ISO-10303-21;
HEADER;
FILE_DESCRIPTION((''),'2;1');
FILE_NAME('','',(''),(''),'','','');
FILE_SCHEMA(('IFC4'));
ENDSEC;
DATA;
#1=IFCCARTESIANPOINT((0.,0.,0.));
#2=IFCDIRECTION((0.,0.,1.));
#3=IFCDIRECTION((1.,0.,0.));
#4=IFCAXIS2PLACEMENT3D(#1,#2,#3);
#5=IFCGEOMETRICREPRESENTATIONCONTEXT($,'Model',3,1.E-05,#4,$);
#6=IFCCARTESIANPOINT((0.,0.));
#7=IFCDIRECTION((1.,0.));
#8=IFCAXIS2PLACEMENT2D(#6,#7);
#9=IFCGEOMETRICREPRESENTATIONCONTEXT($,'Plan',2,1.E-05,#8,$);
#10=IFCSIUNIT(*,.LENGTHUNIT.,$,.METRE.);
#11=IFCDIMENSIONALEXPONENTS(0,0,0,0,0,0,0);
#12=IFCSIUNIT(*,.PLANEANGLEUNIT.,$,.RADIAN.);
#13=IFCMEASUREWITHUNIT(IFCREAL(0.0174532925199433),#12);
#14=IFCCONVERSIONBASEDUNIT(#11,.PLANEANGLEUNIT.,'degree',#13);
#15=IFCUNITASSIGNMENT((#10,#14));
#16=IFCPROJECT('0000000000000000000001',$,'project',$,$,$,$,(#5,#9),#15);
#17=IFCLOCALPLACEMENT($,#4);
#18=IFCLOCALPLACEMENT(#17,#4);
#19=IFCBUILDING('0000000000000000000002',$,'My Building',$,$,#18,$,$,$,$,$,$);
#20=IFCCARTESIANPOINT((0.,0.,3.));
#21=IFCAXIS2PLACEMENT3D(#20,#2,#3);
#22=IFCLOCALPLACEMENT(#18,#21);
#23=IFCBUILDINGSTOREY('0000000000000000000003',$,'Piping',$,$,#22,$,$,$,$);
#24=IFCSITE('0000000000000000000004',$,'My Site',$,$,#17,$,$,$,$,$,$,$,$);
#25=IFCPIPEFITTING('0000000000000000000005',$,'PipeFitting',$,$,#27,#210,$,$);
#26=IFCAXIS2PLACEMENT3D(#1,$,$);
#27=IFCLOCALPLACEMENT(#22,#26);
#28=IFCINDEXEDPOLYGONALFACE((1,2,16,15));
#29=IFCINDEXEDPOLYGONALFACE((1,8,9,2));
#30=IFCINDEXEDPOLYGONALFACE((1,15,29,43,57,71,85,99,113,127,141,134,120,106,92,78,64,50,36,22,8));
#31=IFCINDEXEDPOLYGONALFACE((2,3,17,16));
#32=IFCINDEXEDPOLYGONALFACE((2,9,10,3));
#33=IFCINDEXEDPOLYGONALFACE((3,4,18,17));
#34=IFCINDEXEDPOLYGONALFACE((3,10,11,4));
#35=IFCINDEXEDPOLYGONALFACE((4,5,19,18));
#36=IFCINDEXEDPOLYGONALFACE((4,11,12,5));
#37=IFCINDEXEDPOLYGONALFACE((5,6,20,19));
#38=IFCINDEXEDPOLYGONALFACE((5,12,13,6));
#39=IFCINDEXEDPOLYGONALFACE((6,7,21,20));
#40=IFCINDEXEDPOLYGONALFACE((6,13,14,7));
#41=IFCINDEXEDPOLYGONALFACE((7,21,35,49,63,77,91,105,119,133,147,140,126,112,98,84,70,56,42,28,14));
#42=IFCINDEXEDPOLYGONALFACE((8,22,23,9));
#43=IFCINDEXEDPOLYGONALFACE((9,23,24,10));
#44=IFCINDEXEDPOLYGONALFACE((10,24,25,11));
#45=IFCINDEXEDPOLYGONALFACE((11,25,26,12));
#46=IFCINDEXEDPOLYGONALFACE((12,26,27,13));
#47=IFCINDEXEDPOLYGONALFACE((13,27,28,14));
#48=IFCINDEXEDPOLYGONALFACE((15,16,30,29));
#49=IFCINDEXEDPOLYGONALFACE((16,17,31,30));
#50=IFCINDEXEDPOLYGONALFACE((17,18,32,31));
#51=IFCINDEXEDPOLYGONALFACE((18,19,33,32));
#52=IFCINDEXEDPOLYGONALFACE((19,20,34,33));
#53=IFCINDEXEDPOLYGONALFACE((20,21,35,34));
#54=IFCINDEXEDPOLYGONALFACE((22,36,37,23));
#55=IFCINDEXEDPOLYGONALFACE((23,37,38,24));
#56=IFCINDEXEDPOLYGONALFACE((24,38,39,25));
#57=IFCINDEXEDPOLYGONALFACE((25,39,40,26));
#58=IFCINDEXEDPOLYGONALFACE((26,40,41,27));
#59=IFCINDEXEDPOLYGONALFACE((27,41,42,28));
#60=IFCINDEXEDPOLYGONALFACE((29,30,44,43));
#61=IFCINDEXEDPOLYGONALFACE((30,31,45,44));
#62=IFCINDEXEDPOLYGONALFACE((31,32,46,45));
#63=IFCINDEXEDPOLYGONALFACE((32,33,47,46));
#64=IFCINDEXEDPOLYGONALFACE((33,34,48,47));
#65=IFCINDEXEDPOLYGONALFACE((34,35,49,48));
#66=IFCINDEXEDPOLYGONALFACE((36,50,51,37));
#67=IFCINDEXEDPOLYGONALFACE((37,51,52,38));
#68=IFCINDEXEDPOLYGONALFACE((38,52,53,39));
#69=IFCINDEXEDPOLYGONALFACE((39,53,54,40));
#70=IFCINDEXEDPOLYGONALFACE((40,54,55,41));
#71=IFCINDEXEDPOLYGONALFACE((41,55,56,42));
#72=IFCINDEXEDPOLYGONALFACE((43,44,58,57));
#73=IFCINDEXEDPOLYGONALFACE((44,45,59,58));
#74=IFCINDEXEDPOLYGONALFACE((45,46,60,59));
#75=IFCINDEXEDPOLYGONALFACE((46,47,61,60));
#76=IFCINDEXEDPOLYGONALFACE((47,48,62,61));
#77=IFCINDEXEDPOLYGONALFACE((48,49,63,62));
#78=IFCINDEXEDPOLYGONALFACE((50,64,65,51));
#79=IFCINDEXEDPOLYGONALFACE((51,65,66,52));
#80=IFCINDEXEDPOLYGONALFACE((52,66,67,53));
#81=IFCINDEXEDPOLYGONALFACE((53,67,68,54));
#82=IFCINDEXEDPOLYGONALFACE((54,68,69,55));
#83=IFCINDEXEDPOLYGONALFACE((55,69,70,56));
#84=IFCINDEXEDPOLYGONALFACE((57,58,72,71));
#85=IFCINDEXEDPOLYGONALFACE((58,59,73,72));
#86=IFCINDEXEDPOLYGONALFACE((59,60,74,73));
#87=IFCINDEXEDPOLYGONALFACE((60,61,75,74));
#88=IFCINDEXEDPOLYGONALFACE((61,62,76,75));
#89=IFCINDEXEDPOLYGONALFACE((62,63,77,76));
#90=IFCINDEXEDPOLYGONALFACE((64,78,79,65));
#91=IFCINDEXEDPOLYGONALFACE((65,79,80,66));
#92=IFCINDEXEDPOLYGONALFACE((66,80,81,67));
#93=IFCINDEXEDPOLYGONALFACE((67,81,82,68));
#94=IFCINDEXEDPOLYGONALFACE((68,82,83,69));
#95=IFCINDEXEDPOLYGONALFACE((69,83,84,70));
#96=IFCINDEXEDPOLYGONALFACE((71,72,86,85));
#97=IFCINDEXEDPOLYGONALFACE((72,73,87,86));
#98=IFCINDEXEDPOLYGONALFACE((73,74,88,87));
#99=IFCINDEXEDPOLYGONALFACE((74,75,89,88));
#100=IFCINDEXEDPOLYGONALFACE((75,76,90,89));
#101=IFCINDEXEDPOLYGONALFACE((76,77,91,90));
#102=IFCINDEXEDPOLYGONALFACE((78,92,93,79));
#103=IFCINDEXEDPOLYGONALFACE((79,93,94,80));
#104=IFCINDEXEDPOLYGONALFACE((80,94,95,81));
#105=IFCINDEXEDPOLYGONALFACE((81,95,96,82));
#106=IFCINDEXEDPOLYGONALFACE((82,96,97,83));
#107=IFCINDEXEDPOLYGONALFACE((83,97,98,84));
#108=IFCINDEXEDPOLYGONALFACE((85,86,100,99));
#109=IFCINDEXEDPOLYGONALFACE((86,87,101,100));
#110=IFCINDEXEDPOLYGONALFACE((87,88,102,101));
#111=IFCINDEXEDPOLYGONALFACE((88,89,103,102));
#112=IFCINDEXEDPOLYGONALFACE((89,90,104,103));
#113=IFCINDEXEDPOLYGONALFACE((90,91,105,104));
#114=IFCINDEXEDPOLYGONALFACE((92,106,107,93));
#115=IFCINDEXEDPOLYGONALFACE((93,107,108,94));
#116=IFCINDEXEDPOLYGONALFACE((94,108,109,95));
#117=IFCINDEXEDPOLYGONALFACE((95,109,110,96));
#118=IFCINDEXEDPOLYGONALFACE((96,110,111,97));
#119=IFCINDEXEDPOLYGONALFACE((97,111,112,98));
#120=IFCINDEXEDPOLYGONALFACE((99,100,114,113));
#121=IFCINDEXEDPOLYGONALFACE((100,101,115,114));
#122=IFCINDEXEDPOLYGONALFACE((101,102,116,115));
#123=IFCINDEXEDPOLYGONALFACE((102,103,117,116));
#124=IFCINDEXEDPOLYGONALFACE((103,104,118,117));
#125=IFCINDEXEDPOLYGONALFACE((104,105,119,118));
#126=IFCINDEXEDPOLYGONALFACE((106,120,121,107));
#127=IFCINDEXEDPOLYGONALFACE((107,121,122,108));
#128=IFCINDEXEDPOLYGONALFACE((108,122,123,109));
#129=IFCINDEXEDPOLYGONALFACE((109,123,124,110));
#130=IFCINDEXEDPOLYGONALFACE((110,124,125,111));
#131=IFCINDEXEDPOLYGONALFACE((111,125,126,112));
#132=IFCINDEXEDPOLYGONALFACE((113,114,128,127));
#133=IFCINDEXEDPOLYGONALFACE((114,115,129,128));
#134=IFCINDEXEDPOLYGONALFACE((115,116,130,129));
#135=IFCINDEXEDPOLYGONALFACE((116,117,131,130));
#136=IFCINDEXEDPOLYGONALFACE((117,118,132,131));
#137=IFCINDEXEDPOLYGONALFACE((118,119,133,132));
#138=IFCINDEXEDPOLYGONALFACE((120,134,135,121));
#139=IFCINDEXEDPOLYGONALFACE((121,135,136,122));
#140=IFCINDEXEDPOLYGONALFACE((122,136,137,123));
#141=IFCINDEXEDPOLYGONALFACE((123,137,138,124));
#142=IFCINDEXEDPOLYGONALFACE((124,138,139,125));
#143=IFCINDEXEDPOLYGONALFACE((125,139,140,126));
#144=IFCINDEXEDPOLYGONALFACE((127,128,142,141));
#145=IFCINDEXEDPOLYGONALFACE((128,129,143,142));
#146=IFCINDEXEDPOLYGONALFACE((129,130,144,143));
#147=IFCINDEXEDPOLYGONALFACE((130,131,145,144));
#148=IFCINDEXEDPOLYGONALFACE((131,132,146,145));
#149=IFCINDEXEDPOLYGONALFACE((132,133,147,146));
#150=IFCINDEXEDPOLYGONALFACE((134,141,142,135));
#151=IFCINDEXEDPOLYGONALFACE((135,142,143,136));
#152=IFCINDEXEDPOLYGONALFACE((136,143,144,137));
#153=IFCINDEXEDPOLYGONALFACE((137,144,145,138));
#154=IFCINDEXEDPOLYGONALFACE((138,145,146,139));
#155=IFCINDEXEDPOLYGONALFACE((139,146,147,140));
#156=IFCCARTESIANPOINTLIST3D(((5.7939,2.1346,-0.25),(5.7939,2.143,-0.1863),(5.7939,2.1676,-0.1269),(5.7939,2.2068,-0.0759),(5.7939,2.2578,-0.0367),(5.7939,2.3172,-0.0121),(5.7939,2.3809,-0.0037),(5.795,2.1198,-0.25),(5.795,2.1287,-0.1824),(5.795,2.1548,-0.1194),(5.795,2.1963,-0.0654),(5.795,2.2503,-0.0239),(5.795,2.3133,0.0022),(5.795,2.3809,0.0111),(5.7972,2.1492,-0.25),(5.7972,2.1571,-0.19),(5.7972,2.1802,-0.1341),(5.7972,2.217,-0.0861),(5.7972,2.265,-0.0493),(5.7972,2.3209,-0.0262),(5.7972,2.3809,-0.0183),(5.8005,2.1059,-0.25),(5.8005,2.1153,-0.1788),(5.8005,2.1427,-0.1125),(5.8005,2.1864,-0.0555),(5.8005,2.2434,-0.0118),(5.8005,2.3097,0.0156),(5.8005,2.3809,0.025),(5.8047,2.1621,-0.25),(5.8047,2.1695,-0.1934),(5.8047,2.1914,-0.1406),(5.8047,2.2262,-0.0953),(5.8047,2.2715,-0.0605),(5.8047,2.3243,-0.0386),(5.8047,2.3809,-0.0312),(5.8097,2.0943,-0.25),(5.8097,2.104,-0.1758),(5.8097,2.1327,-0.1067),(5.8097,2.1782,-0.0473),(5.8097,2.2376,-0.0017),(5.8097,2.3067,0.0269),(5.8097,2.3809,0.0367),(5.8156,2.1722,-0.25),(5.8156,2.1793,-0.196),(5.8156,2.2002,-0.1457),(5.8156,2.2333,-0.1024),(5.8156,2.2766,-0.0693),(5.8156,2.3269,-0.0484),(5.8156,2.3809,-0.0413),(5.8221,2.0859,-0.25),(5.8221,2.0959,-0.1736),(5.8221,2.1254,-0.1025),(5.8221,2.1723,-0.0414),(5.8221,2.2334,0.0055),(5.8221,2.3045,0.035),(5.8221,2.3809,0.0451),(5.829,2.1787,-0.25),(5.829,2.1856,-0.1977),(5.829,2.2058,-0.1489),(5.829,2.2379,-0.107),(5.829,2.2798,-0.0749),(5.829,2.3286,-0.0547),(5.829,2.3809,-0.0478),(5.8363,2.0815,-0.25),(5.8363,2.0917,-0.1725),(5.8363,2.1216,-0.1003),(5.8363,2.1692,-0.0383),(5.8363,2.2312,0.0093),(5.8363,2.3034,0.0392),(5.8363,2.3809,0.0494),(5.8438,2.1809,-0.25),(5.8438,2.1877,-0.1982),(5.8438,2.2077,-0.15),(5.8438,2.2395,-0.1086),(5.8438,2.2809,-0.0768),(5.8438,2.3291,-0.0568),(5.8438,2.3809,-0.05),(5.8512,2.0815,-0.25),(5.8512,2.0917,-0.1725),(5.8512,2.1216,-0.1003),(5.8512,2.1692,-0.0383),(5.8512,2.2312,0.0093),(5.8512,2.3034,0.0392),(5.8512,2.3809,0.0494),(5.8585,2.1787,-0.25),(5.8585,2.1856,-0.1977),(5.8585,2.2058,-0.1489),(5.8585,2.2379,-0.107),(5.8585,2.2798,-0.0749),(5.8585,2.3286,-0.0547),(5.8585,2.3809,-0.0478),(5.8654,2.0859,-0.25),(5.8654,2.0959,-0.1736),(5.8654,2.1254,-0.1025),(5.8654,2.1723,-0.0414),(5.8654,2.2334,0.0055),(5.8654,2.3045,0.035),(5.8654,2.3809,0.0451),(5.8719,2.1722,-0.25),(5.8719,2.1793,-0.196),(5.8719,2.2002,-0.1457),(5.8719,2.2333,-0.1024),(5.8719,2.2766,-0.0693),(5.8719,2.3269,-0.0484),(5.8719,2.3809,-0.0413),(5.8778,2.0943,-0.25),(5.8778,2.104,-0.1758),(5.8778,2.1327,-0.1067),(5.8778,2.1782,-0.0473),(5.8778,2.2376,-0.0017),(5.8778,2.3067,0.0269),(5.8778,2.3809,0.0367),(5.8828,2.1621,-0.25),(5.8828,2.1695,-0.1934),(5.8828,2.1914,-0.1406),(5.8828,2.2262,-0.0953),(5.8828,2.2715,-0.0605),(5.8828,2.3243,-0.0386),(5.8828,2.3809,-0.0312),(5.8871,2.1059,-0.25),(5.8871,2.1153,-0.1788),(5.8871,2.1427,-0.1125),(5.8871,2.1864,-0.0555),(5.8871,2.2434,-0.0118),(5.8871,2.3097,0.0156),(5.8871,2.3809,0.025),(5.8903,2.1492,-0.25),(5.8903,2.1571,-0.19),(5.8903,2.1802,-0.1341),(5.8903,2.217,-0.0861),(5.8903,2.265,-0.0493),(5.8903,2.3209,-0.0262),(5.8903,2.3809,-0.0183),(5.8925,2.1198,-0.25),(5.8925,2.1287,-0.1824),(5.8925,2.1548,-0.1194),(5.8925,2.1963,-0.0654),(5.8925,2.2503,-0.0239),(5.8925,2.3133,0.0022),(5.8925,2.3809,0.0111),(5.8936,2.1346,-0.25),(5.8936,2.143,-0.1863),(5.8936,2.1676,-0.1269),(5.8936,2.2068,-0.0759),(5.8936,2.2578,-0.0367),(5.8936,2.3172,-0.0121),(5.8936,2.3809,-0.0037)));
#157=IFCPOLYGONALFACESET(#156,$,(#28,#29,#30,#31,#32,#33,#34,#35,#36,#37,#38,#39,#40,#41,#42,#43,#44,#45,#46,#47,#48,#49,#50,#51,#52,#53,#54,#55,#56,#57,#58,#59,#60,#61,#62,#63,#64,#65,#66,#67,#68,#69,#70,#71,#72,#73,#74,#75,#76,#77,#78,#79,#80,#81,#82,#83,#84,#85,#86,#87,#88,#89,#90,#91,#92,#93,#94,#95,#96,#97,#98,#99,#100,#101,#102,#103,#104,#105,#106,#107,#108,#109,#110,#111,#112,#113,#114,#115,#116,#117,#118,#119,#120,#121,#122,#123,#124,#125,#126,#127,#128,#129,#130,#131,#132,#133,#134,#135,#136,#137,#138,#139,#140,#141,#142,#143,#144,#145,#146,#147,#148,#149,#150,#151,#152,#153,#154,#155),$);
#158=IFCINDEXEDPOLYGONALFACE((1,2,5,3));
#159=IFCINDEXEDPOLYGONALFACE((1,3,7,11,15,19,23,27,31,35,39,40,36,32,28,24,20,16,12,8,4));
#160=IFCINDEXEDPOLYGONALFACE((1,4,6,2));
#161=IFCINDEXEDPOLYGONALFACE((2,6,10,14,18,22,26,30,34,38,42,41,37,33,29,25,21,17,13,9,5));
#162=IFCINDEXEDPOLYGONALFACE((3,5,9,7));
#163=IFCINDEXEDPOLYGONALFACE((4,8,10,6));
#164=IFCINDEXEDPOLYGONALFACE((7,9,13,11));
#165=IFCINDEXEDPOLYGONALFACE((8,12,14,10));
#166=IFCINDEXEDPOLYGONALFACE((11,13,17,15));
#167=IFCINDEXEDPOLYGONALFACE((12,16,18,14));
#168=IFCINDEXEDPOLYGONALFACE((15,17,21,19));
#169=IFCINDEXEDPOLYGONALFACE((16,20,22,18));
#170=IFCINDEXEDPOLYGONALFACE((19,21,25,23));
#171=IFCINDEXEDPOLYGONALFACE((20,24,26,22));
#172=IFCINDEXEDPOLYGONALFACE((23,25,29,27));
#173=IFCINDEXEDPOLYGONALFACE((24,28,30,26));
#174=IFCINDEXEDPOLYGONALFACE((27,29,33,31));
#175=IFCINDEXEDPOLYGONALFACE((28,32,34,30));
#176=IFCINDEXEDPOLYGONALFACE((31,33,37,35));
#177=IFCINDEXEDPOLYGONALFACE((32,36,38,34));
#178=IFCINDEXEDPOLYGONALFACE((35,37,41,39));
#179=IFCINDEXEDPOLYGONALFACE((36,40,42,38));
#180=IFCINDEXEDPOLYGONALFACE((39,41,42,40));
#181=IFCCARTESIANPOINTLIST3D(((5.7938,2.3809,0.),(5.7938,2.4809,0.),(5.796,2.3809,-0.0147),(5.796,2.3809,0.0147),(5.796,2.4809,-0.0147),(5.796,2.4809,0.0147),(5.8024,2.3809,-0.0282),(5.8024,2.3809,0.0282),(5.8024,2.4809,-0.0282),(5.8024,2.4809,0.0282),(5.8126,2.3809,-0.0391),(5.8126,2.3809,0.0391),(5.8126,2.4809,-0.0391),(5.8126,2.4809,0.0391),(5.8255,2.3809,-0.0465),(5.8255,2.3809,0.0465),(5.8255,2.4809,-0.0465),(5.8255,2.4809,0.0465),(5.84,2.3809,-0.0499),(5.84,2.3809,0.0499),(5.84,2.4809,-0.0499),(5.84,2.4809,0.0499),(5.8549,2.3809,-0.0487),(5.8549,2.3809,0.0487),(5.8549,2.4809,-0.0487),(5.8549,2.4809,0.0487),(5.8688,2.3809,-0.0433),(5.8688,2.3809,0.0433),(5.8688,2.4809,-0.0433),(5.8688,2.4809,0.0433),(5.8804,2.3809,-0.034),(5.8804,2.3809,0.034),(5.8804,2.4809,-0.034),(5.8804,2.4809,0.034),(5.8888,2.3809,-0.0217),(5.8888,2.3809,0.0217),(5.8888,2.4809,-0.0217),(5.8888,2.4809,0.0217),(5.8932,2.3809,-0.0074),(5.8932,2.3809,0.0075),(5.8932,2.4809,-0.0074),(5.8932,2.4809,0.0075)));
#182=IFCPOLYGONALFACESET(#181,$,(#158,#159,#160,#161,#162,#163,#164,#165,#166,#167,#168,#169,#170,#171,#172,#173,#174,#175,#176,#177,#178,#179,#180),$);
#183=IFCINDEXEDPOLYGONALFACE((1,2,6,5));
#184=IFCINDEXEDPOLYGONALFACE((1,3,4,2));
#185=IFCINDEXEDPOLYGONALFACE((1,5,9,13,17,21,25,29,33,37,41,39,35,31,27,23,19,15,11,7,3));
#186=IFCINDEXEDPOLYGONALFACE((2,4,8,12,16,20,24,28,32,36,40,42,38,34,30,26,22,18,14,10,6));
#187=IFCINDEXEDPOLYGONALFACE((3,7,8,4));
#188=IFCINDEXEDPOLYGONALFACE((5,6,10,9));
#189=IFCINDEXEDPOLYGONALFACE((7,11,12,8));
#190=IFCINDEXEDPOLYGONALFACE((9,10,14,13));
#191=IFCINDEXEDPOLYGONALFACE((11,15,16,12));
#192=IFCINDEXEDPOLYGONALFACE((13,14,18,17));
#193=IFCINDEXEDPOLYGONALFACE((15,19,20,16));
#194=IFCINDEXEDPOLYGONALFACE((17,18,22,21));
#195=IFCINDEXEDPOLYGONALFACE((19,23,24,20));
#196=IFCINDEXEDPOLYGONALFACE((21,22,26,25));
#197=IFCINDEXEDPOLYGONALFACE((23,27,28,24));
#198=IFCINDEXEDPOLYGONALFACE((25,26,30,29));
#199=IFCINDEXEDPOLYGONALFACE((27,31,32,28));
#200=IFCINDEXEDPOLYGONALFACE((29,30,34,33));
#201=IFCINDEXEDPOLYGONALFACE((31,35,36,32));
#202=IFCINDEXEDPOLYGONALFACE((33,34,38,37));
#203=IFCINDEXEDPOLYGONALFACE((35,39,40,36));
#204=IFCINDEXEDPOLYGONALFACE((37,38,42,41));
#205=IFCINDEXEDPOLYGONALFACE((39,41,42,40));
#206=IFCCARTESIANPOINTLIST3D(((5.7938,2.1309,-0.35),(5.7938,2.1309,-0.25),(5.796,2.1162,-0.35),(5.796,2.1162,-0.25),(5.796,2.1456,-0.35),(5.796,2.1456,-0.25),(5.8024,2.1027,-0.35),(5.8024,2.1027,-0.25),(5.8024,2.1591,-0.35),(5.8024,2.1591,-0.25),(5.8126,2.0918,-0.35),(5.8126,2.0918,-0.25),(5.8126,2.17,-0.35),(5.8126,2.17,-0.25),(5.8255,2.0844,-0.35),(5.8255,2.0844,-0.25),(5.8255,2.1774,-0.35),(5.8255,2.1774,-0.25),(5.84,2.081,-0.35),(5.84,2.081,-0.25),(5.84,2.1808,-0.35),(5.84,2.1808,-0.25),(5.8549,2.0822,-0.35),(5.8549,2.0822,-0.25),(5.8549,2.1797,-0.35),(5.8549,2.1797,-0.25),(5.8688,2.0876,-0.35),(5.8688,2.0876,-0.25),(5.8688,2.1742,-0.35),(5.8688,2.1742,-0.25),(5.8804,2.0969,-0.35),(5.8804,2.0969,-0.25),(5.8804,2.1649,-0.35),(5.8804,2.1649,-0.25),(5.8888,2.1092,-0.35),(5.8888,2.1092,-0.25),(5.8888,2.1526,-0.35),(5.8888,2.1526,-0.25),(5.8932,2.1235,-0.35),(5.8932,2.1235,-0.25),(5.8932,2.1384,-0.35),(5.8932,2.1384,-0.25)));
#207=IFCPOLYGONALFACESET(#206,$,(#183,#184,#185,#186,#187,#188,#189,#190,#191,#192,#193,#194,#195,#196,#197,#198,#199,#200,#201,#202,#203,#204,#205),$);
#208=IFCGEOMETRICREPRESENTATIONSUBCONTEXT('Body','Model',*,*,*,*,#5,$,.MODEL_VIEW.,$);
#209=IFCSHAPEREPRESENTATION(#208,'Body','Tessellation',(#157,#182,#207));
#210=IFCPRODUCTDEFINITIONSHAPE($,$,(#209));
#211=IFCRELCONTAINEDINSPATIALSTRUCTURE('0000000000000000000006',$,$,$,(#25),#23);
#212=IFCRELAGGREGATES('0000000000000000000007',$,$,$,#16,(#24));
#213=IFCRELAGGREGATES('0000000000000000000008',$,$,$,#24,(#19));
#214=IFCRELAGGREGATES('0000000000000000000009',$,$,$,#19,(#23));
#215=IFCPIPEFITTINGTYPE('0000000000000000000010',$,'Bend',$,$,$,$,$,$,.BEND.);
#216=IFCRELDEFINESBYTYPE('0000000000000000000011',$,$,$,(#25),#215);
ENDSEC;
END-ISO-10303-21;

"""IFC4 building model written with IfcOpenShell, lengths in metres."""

from ifc_helpers import new_model, entity, si_unit, converted_unit, frame, origin_with_axes, origin_2d_with_axis, place, context, subcontext, project, spatial, circle, extrude, source, transform, mapped, type_object, type_shapes, element, save


model = new_model("IFC4")

# Units and contexts
model_context = context("Model", 3, precision=1e-05, world=origin_with_axes())
plan_context = context("Plan", 2, precision=1e-05, world=origin_2d_with_axis())
body_context = subcontext(model_context, "Body", "Model", "MODEL_VIEW")
ifc_project = project(units=[si_unit("LENGTHUNIT", "METRE"), converted_unit("PLANEANGLEUNIT", "degree", entity("IfcReal", 0.0174532925199433), si_unit("PLANEANGLEUNIT", "RADIAN"), dimensions=[0, 0, 0, 0, 0, 0, 0])], contexts=[model_context, plan_context])

# Site, building, storey
site_placement = place(None, origin_with_axes())
site = spatial("IfcSite", under=ifc_project, at=site_placement, Name="My Site")
building_placement = place(site_placement, origin_with_axes())
building = spatial("IfcBuilding", under=site, at=building_placement, Name="My Building")
storey_placement = place(building_placement, frame((0.0, 0.0, 3.0), z_axis=(0.0, 0.0, 1.0), x_axis=(1.0, 0.0, 0.0)))
storey = spatial("IfcBuildingStorey", under=building, at=storey_placement, Name="Piping")

# Pipe fitting
pipe_fitting_type = type_object("IfcPipeFittingType", Name="Bend", PredefinedType="BEND")
shared_shape = source(origin_with_axes(), body_context, "Body", "SolidModel", [
    entity("IfcSweptDiskSolid", entity("IfcIndexedPolyCurve", entity("IfcCartesianPointList3D", [[0.0, 0.0, -0.1], [0.0, -0.0732, -0.2768], [0.0, -0.25, -0.35]]), [entity("IfcArcIndex", [1, 2, 3])]), 0.05),
    extrude(circle(Radius=0.05), origin_with_axes(), (0.0, 0.0, -1.0), 0.1),
    extrude(circle(Radius=0.05), frame((0.0, -0.25, -0.35), z_axis=(0.0, -1.0, 0.0), x_axis=(1.0, 0.0, 0.0)), (0.0, 0.0, 1.0), 0.1),
])
type_shapes(pipe_fitting_type, [shared_shape])
for number, where, z_axis, x_axis, name in (
    (1, (5.8438, 2.4809, 0.0), (0.0, 1.0, 0.0), (-1.0, 0.0, 0.0), "PipeFitting"),
):
    element("IfcPipeFitting", number, at=place(storey_placement, frame(where, z_axis=z_axis, x_axis=x_axis)), inside=storey, type_object=pipe_fitting_type, Name=name, context=body_context, shape_type="MappedRepresentation", body=[
        mapped(shared_shape, transform((0.0, 0.0, 0.0), x_axis=(1.0, 0.0, 0.0), y_axis=(0.0, 1.0, 0.0), z_axis=(0.0, 0.0, 1.0), scale=1.0)),
    ])

save(model, "model.ifc")
